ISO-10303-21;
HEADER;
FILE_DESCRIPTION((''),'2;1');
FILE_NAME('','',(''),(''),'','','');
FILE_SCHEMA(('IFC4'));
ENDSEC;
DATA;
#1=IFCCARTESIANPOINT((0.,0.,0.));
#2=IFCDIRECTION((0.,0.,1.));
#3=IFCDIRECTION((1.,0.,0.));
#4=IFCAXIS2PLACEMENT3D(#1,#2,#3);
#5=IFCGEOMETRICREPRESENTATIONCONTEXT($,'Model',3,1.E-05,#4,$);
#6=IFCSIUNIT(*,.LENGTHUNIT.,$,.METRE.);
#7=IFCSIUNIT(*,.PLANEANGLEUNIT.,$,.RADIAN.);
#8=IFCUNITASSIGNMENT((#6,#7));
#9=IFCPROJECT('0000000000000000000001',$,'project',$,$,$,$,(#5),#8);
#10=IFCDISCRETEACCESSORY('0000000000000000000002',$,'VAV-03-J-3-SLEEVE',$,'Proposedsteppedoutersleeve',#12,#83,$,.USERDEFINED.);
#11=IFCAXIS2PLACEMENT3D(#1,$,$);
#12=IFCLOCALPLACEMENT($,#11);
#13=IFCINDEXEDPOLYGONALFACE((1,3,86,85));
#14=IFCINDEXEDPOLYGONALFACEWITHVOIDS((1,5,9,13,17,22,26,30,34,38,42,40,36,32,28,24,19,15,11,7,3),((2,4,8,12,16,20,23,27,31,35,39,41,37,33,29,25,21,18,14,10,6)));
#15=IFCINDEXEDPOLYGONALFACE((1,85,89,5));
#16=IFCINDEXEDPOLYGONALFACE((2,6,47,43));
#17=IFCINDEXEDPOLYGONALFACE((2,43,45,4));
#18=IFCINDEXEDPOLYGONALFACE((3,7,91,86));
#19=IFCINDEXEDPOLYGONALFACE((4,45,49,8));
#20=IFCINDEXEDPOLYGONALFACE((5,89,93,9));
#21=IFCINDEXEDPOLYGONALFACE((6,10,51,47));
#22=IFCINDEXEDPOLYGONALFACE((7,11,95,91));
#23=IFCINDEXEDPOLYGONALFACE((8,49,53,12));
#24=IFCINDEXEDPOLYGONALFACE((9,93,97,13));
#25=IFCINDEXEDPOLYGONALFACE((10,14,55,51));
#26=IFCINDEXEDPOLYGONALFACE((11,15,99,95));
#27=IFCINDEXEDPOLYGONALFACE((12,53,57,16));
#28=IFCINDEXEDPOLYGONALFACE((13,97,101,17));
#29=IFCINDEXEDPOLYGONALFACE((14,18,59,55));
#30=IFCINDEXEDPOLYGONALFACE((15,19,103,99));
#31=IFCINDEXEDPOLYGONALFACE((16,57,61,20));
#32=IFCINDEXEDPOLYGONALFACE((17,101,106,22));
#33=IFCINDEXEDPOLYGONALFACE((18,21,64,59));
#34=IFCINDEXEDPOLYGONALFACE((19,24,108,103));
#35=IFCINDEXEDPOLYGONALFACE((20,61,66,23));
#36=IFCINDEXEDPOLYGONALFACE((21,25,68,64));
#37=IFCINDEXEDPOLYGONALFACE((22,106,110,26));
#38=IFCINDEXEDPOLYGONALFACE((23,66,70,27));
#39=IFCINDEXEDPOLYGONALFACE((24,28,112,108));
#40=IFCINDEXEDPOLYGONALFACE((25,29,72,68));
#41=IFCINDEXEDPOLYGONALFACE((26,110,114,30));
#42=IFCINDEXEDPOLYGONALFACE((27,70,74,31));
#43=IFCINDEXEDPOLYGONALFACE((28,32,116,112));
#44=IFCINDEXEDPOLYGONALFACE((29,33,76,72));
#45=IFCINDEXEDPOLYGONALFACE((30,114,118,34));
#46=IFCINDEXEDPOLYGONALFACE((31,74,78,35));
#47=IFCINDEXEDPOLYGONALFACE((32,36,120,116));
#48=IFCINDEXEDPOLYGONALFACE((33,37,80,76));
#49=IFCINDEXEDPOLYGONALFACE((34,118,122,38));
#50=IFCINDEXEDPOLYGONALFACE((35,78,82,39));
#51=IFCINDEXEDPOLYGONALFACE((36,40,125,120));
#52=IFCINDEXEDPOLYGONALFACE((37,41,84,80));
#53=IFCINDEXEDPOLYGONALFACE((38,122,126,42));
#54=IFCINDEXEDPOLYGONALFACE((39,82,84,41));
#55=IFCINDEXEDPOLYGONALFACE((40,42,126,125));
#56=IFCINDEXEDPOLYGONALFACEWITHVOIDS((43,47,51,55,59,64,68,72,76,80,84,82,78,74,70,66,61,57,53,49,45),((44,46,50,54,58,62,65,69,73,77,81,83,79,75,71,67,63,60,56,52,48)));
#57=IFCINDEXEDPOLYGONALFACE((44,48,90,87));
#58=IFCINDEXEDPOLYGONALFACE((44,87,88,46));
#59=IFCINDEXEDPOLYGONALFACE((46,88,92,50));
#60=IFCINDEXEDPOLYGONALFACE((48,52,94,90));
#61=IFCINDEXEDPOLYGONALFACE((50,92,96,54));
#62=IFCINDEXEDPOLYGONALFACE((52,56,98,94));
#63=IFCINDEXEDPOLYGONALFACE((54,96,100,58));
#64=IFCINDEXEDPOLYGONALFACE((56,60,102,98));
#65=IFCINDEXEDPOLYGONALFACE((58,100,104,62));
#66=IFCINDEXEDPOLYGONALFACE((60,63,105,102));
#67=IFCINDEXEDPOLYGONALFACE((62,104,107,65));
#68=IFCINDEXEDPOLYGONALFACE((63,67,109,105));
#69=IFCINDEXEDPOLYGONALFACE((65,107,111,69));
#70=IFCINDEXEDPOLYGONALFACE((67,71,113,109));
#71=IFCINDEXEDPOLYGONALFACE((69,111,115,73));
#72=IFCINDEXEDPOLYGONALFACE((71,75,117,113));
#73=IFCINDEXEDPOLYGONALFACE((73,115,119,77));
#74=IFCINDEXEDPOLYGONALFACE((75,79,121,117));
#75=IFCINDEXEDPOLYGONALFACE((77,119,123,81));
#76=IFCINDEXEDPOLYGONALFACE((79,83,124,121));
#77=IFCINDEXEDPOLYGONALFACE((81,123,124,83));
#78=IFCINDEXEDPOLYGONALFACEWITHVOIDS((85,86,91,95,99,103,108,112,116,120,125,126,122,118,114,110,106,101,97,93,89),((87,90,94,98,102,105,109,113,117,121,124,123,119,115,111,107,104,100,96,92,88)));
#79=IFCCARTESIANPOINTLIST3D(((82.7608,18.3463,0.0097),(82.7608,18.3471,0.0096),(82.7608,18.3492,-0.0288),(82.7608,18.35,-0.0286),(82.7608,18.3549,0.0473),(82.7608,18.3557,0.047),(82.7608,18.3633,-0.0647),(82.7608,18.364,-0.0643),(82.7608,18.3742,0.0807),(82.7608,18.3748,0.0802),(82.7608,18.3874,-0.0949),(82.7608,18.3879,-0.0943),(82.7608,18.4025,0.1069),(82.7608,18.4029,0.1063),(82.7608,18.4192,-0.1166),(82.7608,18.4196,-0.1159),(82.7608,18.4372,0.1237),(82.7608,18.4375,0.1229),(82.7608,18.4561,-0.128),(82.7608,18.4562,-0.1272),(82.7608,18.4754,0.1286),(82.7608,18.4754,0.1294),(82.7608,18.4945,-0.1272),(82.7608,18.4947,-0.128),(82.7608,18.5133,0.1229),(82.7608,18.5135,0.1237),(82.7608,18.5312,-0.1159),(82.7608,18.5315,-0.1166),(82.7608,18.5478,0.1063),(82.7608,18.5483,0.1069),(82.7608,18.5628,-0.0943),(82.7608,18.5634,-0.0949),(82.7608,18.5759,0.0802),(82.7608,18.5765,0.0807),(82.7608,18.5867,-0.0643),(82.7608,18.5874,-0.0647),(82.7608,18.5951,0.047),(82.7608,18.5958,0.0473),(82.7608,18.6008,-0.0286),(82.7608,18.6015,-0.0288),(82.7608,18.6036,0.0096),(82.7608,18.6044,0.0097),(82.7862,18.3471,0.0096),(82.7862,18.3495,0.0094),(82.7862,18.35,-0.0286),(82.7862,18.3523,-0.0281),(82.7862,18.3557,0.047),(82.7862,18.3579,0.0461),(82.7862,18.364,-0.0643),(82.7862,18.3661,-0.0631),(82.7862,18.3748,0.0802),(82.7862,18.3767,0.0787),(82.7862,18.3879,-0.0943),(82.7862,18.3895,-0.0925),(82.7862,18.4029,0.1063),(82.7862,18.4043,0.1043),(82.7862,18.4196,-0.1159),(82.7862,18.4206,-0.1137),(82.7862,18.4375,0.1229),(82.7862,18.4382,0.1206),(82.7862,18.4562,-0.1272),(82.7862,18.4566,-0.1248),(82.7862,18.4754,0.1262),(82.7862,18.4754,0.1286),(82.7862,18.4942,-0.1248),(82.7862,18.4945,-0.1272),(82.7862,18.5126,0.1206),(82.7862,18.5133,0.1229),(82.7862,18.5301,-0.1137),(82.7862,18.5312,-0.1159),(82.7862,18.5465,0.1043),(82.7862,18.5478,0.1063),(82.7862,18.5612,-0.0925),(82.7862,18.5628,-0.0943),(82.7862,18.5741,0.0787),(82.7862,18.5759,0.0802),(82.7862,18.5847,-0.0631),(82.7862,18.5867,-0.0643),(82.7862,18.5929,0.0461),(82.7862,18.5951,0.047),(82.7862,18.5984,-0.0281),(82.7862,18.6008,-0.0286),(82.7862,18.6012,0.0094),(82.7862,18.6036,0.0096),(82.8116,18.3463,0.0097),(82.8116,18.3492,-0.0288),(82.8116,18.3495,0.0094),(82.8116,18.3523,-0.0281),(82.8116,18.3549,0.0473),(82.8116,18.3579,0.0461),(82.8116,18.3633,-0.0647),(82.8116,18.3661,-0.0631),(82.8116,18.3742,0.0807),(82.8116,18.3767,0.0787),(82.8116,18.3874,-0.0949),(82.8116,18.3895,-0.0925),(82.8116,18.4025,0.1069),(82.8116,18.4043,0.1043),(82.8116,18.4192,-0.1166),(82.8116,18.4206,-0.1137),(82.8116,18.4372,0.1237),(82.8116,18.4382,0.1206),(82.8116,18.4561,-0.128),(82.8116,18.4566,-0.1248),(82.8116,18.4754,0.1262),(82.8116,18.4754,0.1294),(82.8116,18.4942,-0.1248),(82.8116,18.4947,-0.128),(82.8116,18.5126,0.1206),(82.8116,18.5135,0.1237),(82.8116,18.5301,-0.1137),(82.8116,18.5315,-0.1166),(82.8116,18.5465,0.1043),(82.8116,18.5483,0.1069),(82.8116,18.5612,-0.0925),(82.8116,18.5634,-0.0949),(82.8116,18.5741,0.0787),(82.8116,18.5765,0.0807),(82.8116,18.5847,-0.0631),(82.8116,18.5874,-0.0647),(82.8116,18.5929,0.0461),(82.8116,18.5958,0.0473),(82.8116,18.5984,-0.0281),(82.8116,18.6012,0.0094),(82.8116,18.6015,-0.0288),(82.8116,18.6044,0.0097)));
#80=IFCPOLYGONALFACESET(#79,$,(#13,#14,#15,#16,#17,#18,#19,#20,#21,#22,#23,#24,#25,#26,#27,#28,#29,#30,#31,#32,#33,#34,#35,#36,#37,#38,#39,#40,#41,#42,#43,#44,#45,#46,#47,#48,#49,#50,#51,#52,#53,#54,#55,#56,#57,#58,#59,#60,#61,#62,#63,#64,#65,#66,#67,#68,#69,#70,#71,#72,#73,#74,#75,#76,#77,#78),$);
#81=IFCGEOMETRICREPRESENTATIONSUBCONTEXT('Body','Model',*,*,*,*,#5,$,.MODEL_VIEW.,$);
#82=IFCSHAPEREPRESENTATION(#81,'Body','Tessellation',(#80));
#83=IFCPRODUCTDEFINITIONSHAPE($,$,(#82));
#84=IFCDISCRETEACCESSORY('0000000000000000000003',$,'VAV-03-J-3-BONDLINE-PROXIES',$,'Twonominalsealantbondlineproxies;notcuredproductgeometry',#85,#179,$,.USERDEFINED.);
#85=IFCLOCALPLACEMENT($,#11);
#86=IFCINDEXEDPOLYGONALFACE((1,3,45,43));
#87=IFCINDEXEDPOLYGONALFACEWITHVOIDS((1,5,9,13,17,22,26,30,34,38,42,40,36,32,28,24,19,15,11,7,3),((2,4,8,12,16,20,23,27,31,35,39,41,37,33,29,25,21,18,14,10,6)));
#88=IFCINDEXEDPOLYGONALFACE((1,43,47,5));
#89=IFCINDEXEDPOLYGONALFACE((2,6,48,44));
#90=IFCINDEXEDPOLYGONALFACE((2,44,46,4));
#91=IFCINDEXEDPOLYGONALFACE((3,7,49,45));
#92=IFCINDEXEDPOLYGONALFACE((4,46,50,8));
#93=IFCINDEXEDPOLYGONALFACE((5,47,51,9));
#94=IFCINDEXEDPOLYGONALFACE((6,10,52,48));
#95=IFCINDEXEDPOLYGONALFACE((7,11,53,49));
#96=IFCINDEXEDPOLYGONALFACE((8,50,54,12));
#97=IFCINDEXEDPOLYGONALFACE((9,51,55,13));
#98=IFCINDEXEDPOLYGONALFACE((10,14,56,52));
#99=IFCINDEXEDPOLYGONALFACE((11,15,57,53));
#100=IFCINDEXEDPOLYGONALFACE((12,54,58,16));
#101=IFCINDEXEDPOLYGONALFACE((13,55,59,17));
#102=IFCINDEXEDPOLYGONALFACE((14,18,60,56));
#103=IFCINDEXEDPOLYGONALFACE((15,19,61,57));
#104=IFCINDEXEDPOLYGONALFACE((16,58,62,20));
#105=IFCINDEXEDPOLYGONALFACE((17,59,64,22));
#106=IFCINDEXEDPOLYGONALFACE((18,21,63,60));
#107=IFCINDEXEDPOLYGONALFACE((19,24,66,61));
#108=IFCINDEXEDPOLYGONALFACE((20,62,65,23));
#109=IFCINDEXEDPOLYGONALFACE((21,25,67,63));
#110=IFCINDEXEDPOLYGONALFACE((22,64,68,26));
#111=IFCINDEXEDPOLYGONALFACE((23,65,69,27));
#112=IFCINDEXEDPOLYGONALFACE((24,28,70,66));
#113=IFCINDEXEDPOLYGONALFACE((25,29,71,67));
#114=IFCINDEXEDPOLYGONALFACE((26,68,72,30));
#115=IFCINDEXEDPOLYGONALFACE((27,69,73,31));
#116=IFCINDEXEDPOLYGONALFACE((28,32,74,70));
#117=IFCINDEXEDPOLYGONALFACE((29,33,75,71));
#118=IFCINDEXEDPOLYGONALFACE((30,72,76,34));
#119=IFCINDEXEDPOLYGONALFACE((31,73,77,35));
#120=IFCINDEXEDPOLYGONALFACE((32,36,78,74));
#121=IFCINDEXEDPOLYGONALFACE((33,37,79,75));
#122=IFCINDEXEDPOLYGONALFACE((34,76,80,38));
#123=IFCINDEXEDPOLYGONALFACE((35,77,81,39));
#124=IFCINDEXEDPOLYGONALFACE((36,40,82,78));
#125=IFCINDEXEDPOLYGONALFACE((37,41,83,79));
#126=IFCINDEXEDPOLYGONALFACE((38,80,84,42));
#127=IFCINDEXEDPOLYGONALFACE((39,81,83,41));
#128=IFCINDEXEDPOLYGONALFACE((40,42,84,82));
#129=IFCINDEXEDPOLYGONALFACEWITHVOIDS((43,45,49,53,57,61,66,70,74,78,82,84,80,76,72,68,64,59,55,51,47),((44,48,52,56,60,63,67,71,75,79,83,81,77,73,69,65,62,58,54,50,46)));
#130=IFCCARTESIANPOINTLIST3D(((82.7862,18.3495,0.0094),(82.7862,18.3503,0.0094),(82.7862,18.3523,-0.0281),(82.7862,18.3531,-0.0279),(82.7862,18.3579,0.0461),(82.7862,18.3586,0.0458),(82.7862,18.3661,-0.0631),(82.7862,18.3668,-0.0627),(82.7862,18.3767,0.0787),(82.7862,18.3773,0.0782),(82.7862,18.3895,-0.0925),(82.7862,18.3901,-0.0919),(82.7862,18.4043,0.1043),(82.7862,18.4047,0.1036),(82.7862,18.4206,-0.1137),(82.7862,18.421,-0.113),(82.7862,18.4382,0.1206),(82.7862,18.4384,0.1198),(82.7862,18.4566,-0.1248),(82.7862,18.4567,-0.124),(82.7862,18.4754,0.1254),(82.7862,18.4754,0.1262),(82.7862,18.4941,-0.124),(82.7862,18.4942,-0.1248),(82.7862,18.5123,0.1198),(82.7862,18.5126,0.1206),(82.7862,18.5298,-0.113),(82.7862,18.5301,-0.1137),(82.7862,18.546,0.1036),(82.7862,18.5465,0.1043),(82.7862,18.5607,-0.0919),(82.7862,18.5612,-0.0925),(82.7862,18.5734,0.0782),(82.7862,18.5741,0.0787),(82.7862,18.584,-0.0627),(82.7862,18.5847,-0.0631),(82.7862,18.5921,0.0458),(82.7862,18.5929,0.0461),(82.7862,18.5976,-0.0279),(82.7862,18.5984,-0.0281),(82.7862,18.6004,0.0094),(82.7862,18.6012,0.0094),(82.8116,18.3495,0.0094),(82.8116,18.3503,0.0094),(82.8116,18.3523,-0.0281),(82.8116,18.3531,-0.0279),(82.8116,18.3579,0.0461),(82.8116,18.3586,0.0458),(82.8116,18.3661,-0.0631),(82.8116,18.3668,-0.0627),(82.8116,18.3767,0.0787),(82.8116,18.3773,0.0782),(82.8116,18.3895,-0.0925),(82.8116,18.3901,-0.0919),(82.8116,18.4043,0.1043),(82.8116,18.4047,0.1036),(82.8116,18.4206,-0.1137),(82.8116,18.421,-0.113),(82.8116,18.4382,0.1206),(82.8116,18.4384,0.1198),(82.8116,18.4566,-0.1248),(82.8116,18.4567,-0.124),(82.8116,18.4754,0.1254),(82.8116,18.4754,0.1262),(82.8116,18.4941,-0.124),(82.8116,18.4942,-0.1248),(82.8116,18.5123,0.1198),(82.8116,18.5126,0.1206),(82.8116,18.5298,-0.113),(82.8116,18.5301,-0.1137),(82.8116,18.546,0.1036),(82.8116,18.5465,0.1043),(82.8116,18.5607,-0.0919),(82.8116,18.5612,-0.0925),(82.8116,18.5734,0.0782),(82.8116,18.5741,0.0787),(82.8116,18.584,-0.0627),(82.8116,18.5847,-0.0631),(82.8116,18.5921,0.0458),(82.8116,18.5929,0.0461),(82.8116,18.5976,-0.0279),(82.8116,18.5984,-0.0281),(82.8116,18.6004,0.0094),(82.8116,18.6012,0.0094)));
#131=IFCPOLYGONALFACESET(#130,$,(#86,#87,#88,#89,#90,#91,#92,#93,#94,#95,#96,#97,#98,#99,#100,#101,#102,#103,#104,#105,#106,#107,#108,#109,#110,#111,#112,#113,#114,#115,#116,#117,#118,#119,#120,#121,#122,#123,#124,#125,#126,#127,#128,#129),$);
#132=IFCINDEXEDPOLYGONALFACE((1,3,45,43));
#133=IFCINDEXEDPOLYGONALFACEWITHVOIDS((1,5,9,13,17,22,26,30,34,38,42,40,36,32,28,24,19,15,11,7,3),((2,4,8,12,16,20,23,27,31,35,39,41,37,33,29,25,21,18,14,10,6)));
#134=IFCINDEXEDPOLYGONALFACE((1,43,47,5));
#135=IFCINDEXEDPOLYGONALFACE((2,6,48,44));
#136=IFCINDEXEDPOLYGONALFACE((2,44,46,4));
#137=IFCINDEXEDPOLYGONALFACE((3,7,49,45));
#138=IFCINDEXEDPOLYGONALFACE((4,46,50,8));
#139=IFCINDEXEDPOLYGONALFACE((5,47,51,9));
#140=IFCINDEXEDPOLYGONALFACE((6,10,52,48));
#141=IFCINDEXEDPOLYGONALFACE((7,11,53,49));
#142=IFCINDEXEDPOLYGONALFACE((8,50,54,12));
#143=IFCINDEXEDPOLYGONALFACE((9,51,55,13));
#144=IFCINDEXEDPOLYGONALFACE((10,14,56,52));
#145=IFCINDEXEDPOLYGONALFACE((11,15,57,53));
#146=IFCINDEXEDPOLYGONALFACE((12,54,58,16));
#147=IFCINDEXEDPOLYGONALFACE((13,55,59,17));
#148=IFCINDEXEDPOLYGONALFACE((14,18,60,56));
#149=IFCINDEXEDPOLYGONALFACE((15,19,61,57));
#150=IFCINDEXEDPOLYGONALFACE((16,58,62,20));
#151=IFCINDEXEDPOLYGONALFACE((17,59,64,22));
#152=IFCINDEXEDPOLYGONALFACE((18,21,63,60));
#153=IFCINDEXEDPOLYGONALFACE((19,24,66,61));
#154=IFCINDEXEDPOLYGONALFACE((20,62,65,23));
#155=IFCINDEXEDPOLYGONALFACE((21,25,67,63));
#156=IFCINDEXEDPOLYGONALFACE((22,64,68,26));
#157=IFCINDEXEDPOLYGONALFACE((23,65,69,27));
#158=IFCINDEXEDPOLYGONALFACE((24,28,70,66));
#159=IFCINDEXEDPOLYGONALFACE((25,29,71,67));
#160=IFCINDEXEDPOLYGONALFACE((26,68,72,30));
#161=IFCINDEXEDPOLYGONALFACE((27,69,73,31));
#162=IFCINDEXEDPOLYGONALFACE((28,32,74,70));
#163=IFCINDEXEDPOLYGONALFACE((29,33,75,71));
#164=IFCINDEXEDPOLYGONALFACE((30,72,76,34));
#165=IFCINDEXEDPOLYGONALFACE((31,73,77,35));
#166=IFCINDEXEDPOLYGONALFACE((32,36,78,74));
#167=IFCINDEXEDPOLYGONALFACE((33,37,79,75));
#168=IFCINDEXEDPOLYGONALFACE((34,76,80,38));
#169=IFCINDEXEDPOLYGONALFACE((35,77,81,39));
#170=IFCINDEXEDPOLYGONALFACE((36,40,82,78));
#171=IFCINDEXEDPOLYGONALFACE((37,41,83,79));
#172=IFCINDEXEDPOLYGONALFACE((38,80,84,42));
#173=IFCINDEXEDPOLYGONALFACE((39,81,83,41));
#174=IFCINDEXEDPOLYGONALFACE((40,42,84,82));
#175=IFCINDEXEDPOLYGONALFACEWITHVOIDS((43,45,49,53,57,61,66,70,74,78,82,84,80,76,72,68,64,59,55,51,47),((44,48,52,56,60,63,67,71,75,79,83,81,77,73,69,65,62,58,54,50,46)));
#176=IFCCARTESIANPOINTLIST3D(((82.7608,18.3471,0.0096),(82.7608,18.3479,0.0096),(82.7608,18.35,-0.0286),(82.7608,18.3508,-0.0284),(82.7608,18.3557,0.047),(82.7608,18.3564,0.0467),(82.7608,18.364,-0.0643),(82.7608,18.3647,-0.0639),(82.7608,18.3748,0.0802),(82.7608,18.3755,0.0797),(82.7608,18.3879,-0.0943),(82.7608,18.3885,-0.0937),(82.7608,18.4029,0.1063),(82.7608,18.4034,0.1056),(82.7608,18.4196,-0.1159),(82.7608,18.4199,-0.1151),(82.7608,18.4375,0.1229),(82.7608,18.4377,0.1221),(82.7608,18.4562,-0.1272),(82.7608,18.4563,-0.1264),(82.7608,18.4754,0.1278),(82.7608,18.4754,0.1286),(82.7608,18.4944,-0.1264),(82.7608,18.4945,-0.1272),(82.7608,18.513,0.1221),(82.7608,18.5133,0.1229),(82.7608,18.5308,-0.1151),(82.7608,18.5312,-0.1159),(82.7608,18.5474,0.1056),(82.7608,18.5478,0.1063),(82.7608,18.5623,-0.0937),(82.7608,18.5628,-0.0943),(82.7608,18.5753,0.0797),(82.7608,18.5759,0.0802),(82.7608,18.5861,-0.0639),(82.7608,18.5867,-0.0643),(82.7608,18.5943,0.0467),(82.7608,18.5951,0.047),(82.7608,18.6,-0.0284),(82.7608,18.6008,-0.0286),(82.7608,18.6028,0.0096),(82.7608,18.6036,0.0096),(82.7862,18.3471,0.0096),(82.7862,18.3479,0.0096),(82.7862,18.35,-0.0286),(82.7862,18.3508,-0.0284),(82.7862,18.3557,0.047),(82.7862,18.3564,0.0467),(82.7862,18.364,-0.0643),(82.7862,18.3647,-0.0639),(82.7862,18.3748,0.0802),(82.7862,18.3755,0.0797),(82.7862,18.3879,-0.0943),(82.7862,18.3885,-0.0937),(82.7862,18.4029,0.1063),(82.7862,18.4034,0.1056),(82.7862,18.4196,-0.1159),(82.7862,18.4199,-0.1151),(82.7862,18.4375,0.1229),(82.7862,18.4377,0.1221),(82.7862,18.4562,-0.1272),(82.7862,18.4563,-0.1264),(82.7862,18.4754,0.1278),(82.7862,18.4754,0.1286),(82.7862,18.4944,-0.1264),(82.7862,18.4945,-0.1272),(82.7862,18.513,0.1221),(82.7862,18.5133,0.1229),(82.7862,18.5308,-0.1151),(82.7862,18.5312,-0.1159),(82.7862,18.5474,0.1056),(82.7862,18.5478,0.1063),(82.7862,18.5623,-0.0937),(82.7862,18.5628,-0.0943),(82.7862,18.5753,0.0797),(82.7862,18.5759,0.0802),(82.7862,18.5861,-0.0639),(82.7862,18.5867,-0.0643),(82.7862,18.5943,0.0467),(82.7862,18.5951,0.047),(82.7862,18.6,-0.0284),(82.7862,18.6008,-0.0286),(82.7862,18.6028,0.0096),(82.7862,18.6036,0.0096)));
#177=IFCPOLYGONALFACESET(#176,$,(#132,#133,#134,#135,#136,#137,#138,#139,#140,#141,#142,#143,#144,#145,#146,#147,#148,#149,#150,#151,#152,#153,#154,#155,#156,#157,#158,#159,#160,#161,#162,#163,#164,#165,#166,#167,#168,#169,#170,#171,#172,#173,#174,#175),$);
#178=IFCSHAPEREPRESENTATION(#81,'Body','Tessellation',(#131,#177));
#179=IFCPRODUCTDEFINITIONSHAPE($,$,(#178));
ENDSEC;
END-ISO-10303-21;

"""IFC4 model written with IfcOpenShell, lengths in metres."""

from ifc_helpers import new_model, entity, si_unit, frame, origin_with_axes, place, context, subcontext, project, element, save


model = new_model("IFC4")

# Units and contexts
model_context = context("Model", 3, precision=1e-05, world=origin_with_axes())
body_context = subcontext(model_context, "Body", "Model", "MODEL_VIEW")
ifc_project = project(units=[si_unit("LENGTHUNIT", "METRE"), si_unit("PLANEANGLEUNIT", "RADIAN")], contexts=[model_context])

# Discrete accessories
discrete_accessory_1_placement = place(None, frame((82.7862, 18.4754, 0.0), z_axis=(0.0, -1.0, 0.0), x_axis=(0.0, 0.0, 1.0)))
element("IfcDiscreteAccessory", 1, at=discrete_accessory_1_placement, Name="VAV-03-J-3-SLEEVE", ObjectType="Proposedsteppedoutersleeve", PredefinedType="USERDEFINED", context=body_context, shape_type="SweptSolid", body=[
    entity("IfcRevolvedAreaSolid", entity("IfcArbitraryClosedProfileDef", "AREA", None, entity("IfcPolyline", [entity("IfcCartesianPoint", [0.1262, -0.0254]), entity("IfcCartesianPoint", [0.1294, -0.0254]), entity("IfcCartesianPoint", [0.1294, 0.0254]), entity("IfcCartesianPoint", [0.1286, 0.0254]), entity("IfcCartesianPoint", [0.1286, 0.0]), entity("IfcCartesianPoint", [0.1262, 0.0]), entity("IfcCartesianPoint", [0.1262, -0.0254])])), entity("IfcAxis2Placement3D", entity("IfcCartesianPoint", [0.0, 0.0, 0.0])), entity("IfcAxis1Placement", entity("IfcCartesianPoint", [0.0, 0.0, 0.0]), entity("IfcDirection", [0.0, 1.0, 0.0])), 6.283185),
])
discrete_accessory_2_placement = place(None, frame((82.7862, 18.4754, 0.0), z_axis=(0.0, -1.0, 0.0), x_axis=(0.0, 0.0, 1.0)))
element("IfcDiscreteAccessory", 2, at=discrete_accessory_2_placement, Name="VAV-03-J-3-BONDLINE-PROXIES", ObjectType="Twonominalsealantbondlineproxies;notcuredproductgeometry", PredefinedType="USERDEFINED", context=body_context, shape_type="SweptSolid", body=[
    entity("IfcRevolvedAreaSolid", entity("IfcArbitraryClosedProfileDef", "AREA", None, entity("IfcPolyline", [entity("IfcCartesianPoint", [0.1254, -0.0254]), entity("IfcCartesianPoint", [0.1262, -0.0254]), entity("IfcCartesianPoint", [0.1262, 0.0]), entity("IfcCartesianPoint", [0.1254, 0.0]), entity("IfcCartesianPoint", [0.1254, -0.0254])])), entity("IfcAxis2Placement3D", entity("IfcCartesianPoint", [0.0, 0.0, 0.0])), entity("IfcAxis1Placement", entity("IfcCartesianPoint", [0.0, 0.0, 0.0]), entity("IfcDirection", [0.0, 1.0, 0.0])), 6.283185),
    entity("IfcRevolvedAreaSolid", entity("IfcArbitraryClosedProfileDef", "AREA", None, entity("IfcPolyline", [entity("IfcCartesianPoint", [0.1278, 0.0]), entity("IfcCartesianPoint", [0.1286, 0.0]), entity("IfcCartesianPoint", [0.1286, 0.0254]), entity("IfcCartesianPoint", [0.1278, 0.0254]), entity("IfcCartesianPoint", [0.1278, 0.0])])), entity("IfcAxis2Placement3D", entity("IfcCartesianPoint", [0.0, 0.0, 0.0])), entity("IfcAxis1Placement", entity("IfcCartesianPoint", [0.0, 0.0, 0.0]), entity("IfcDirection", [0.0, 1.0, 0.0])), 6.283185),
])

save(model, "model.ifc")
